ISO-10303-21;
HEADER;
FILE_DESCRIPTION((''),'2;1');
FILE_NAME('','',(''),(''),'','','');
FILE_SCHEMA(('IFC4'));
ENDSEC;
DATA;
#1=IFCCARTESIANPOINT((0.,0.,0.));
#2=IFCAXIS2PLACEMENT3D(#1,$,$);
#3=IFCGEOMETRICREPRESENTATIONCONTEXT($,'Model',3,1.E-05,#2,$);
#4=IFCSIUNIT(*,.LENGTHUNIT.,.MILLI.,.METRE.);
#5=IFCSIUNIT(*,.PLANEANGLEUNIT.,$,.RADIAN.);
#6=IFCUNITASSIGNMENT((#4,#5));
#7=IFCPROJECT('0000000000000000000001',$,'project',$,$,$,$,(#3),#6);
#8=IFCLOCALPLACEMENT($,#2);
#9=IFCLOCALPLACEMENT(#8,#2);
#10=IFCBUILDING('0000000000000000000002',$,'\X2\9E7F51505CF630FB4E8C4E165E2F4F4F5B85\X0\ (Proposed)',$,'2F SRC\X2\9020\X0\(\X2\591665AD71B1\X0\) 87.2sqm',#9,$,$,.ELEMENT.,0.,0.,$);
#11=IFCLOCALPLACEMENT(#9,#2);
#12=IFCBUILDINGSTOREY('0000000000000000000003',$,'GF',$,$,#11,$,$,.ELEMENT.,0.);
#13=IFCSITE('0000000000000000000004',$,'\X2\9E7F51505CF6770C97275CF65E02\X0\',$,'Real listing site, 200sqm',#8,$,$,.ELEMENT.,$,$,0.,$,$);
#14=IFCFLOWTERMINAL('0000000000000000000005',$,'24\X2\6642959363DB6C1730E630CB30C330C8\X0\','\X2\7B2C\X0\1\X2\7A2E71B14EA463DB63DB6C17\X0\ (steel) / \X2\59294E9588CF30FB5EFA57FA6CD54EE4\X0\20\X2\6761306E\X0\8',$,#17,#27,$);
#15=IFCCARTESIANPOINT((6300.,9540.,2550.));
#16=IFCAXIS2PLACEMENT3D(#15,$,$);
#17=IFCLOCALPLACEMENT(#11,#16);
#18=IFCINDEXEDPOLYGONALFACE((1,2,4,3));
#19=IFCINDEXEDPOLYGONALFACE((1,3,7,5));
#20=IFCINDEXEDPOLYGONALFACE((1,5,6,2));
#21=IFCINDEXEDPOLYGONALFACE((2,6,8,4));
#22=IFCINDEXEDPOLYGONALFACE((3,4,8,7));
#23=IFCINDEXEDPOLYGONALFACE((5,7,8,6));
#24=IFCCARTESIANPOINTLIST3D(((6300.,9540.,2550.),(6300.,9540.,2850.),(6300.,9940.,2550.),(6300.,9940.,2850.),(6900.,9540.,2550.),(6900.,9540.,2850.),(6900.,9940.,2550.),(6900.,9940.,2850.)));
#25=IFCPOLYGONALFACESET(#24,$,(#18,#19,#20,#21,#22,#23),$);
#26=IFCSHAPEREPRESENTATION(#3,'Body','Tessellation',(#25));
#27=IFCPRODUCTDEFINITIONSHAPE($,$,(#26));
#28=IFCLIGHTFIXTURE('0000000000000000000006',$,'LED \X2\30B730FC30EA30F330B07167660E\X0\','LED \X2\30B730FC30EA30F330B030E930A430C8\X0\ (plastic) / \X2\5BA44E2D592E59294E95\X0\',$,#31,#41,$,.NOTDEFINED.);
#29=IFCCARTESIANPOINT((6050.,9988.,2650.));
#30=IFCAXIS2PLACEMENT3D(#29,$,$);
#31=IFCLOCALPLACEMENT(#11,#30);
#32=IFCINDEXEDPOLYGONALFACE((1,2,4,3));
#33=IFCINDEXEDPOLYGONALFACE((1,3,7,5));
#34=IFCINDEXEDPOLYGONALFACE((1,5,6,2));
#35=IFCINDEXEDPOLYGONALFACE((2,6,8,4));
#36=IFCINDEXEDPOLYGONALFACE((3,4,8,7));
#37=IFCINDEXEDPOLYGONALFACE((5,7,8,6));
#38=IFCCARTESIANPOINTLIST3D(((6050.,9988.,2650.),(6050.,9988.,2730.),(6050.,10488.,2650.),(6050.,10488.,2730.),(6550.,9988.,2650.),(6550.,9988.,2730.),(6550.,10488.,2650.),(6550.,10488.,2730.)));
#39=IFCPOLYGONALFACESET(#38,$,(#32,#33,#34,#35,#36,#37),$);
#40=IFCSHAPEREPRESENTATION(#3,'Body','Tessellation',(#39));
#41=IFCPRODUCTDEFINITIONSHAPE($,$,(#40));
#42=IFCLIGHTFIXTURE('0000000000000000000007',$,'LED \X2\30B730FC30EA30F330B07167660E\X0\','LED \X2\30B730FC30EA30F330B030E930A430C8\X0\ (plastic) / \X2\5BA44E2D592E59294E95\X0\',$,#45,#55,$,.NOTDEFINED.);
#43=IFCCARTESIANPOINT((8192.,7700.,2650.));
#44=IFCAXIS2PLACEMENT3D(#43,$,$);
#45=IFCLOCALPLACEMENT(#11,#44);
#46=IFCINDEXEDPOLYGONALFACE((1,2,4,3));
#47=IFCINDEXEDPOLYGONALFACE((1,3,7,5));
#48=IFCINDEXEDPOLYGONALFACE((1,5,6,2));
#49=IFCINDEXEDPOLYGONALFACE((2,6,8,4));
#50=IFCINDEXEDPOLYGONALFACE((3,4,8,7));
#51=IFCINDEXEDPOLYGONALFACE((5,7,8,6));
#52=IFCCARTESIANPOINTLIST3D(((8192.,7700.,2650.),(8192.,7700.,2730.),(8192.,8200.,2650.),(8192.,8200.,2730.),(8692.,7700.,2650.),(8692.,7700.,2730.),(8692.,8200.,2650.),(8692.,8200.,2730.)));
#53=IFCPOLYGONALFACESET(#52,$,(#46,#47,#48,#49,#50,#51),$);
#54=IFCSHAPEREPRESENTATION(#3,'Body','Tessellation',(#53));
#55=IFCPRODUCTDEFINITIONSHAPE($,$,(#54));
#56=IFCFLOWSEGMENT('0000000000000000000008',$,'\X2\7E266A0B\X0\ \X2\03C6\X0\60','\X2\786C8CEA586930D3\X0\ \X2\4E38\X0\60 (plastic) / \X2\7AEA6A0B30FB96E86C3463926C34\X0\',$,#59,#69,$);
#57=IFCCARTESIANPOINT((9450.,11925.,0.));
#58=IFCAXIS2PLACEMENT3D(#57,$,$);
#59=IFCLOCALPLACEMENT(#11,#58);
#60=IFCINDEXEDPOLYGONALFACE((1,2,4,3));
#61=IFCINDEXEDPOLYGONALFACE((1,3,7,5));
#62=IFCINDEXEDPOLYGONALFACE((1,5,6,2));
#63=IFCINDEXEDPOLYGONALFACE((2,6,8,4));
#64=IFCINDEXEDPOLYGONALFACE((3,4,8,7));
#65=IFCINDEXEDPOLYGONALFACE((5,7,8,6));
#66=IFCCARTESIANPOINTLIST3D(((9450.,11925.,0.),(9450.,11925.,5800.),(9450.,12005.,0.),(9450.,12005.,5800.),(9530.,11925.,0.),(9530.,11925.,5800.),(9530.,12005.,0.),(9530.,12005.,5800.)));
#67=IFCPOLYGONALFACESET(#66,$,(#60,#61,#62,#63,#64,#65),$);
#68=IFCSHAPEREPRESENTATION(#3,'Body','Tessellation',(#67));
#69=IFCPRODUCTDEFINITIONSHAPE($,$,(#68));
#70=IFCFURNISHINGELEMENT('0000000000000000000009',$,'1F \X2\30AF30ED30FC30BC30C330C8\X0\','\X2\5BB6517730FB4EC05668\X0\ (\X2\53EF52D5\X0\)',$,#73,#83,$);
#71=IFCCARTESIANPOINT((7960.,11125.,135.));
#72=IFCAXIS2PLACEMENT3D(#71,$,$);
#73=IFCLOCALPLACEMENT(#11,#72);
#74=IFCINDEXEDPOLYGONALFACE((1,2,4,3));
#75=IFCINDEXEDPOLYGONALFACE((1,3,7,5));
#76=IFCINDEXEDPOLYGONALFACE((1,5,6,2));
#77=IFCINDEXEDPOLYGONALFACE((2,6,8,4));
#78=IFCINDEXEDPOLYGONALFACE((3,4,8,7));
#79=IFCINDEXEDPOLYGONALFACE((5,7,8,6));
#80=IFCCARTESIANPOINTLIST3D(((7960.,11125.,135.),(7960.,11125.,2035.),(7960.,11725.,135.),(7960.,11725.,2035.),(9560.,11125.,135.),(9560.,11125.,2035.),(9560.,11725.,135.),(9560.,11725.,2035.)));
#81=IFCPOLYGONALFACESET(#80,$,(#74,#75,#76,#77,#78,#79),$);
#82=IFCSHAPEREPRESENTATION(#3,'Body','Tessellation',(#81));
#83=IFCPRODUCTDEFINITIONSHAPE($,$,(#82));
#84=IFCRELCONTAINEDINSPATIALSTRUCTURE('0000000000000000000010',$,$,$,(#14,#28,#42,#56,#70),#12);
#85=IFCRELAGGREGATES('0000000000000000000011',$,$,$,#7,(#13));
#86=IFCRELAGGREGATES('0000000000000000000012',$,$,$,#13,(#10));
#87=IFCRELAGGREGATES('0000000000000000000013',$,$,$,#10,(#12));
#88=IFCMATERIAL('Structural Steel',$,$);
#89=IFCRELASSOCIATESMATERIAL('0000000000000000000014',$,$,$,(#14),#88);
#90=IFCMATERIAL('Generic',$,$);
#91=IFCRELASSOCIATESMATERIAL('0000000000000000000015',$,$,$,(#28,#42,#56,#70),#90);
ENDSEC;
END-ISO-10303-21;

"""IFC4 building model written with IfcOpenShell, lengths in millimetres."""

from ifc_helpers import new_model, si_unit, frame, frame_2d, origin, place, context, project, spatial, rectangle, extrude, material, element, save


model = new_model("IFC4")

# Units and contexts
model_context = context("Model", 3, precision=1e-05, world=origin())
ifc_project = project(units=[si_unit("LENGTHUNIT", "METRE", prefix="MILLI"), si_unit("PLANEANGLEUNIT", "RADIAN")], contexts=[model_context])

# Site, building, storey
site_placement = place(None, origin())
site = spatial("IfcSite", under=ifc_project, at=site_placement, Name="鹿児島県霧島市", ObjectType="Real listing site, 200sqm", CompositionType="ELEMENT", RefElevation=0.0)
building_placement = place(site_placement, origin())
building = spatial("IfcBuilding", under=site, at=building_placement, Name="鹿児島・二世帯住宅 (Proposed)", ObjectType="2F SRC造(外断熱) 87.2sqm", CompositionType="ELEMENT", ElevationOfRefHeight=0.0, ElevationOfTerrain=0.0)
storey_placement = place(building_placement, origin())
storey = spatial("IfcBuildingStorey", under=building, at=storey_placement, Name="GF", CompositionType="ELEMENT", Elevation=0.0)

# Shared definitions
ifc_material_1 = material(Name="Generic")

# Flow terminal
ifc_material_2 = material(Name="Structural Steel")
flow_terminal_placement = place(storey_placement, frame((6300.0, 9540.0, 2550.0)))
element("IfcFlowTerminal", 1, at=flow_terminal_placement, inside=storey, material=ifc_material_2, Name="24時間換気ユニット", Description="第1種熱交換換気 (steel) / 天井裏・建基法令20条の8", context=model_context, shape_type="SweptSolid", body=[
    extrude(rectangle(XDim=600.0, YDim=400.0, at=frame_2d((300.0, 200.0))), frame((6300.0, 9540.0, 2550.0)), (0.0, 0.0, 1.0), 300.0),
])

# Light fixtures
light_fixture_1_placement = place(storey_placement, frame((6050.0, 9988.0, 2650.0)))
element("IfcLightFixture", 2, at=light_fixture_1_placement, inside=storey, material=ifc_material_1, Name="LED シーリング照明", Description="LED シーリングライト (plastic) / 室中央天井", PredefinedType="NOTDEFINED", context=model_context, shape_type="SweptSolid", body=[
    extrude(rectangle(XDim=500.0, YDim=500.0, at=frame_2d((250.0, 250.0))), frame((6050.0, 9988.0, 2650.0)), (0.0, 0.0, 1.0), 80.0),
])
light_fixture_2_placement = place(storey_placement, frame((8192.0, 7700.0, 2650.0)))
element("IfcLightFixture", 3, at=light_fixture_2_placement, inside=storey, material=ifc_material_1, Name="LED シーリング照明", Description="LED シーリングライト (plastic) / 室中央天井", PredefinedType="NOTDEFINED", context=model_context, shape_type="SweptSolid", body=[
    extrude(rectangle(XDim=500.0, YDim=500.0, at=frame_2d((250.0, 250.0))), frame((8192.0, 7700.0, 2650.0)), (0.0, 0.0, 1.0), 80.0),
])

# Flow segment
flow_segment_placement = place(storey_placement, frame((9450.0, 11925.0, 0.0)))
element("IfcFlowSegment", 4, at=flow_segment_placement, inside=storey, material=ifc_material_1, Name="縦樋 φ60", Description="硬質塩ビ 丸60 (plastic) / 竪樋・雨水排水", context=model_context, shape_type="SweptSolid", body=[
    extrude(rectangle(XDim=80.0, YDim=80.0, at=frame_2d((40.0, 40.0))), frame((9450.0, 11925.0, 0.0)), (0.0, 0.0, 1.0), 5800.0),
])

# Furnishing element
furnishing_placement = place(storey_placement, frame((7960.0, 11125.0, 135.0)))
element("IfcFurnishingElement", 5, at=furnishing_placement, inside=storey, material=ifc_material_1, Name="1F クローゼット", Description="家具・什器 (可動)", context=model_context, shape_type="SweptSolid", body=[
    extrude(rectangle(XDim=1600.0, YDim=600.0, at=frame_2d((800.0, 300.0))), frame((7960.0, 11125.0, 135.0)), (0.0, 0.0, 1.0), 1900.0),
])

save(model, "model.ifc")
